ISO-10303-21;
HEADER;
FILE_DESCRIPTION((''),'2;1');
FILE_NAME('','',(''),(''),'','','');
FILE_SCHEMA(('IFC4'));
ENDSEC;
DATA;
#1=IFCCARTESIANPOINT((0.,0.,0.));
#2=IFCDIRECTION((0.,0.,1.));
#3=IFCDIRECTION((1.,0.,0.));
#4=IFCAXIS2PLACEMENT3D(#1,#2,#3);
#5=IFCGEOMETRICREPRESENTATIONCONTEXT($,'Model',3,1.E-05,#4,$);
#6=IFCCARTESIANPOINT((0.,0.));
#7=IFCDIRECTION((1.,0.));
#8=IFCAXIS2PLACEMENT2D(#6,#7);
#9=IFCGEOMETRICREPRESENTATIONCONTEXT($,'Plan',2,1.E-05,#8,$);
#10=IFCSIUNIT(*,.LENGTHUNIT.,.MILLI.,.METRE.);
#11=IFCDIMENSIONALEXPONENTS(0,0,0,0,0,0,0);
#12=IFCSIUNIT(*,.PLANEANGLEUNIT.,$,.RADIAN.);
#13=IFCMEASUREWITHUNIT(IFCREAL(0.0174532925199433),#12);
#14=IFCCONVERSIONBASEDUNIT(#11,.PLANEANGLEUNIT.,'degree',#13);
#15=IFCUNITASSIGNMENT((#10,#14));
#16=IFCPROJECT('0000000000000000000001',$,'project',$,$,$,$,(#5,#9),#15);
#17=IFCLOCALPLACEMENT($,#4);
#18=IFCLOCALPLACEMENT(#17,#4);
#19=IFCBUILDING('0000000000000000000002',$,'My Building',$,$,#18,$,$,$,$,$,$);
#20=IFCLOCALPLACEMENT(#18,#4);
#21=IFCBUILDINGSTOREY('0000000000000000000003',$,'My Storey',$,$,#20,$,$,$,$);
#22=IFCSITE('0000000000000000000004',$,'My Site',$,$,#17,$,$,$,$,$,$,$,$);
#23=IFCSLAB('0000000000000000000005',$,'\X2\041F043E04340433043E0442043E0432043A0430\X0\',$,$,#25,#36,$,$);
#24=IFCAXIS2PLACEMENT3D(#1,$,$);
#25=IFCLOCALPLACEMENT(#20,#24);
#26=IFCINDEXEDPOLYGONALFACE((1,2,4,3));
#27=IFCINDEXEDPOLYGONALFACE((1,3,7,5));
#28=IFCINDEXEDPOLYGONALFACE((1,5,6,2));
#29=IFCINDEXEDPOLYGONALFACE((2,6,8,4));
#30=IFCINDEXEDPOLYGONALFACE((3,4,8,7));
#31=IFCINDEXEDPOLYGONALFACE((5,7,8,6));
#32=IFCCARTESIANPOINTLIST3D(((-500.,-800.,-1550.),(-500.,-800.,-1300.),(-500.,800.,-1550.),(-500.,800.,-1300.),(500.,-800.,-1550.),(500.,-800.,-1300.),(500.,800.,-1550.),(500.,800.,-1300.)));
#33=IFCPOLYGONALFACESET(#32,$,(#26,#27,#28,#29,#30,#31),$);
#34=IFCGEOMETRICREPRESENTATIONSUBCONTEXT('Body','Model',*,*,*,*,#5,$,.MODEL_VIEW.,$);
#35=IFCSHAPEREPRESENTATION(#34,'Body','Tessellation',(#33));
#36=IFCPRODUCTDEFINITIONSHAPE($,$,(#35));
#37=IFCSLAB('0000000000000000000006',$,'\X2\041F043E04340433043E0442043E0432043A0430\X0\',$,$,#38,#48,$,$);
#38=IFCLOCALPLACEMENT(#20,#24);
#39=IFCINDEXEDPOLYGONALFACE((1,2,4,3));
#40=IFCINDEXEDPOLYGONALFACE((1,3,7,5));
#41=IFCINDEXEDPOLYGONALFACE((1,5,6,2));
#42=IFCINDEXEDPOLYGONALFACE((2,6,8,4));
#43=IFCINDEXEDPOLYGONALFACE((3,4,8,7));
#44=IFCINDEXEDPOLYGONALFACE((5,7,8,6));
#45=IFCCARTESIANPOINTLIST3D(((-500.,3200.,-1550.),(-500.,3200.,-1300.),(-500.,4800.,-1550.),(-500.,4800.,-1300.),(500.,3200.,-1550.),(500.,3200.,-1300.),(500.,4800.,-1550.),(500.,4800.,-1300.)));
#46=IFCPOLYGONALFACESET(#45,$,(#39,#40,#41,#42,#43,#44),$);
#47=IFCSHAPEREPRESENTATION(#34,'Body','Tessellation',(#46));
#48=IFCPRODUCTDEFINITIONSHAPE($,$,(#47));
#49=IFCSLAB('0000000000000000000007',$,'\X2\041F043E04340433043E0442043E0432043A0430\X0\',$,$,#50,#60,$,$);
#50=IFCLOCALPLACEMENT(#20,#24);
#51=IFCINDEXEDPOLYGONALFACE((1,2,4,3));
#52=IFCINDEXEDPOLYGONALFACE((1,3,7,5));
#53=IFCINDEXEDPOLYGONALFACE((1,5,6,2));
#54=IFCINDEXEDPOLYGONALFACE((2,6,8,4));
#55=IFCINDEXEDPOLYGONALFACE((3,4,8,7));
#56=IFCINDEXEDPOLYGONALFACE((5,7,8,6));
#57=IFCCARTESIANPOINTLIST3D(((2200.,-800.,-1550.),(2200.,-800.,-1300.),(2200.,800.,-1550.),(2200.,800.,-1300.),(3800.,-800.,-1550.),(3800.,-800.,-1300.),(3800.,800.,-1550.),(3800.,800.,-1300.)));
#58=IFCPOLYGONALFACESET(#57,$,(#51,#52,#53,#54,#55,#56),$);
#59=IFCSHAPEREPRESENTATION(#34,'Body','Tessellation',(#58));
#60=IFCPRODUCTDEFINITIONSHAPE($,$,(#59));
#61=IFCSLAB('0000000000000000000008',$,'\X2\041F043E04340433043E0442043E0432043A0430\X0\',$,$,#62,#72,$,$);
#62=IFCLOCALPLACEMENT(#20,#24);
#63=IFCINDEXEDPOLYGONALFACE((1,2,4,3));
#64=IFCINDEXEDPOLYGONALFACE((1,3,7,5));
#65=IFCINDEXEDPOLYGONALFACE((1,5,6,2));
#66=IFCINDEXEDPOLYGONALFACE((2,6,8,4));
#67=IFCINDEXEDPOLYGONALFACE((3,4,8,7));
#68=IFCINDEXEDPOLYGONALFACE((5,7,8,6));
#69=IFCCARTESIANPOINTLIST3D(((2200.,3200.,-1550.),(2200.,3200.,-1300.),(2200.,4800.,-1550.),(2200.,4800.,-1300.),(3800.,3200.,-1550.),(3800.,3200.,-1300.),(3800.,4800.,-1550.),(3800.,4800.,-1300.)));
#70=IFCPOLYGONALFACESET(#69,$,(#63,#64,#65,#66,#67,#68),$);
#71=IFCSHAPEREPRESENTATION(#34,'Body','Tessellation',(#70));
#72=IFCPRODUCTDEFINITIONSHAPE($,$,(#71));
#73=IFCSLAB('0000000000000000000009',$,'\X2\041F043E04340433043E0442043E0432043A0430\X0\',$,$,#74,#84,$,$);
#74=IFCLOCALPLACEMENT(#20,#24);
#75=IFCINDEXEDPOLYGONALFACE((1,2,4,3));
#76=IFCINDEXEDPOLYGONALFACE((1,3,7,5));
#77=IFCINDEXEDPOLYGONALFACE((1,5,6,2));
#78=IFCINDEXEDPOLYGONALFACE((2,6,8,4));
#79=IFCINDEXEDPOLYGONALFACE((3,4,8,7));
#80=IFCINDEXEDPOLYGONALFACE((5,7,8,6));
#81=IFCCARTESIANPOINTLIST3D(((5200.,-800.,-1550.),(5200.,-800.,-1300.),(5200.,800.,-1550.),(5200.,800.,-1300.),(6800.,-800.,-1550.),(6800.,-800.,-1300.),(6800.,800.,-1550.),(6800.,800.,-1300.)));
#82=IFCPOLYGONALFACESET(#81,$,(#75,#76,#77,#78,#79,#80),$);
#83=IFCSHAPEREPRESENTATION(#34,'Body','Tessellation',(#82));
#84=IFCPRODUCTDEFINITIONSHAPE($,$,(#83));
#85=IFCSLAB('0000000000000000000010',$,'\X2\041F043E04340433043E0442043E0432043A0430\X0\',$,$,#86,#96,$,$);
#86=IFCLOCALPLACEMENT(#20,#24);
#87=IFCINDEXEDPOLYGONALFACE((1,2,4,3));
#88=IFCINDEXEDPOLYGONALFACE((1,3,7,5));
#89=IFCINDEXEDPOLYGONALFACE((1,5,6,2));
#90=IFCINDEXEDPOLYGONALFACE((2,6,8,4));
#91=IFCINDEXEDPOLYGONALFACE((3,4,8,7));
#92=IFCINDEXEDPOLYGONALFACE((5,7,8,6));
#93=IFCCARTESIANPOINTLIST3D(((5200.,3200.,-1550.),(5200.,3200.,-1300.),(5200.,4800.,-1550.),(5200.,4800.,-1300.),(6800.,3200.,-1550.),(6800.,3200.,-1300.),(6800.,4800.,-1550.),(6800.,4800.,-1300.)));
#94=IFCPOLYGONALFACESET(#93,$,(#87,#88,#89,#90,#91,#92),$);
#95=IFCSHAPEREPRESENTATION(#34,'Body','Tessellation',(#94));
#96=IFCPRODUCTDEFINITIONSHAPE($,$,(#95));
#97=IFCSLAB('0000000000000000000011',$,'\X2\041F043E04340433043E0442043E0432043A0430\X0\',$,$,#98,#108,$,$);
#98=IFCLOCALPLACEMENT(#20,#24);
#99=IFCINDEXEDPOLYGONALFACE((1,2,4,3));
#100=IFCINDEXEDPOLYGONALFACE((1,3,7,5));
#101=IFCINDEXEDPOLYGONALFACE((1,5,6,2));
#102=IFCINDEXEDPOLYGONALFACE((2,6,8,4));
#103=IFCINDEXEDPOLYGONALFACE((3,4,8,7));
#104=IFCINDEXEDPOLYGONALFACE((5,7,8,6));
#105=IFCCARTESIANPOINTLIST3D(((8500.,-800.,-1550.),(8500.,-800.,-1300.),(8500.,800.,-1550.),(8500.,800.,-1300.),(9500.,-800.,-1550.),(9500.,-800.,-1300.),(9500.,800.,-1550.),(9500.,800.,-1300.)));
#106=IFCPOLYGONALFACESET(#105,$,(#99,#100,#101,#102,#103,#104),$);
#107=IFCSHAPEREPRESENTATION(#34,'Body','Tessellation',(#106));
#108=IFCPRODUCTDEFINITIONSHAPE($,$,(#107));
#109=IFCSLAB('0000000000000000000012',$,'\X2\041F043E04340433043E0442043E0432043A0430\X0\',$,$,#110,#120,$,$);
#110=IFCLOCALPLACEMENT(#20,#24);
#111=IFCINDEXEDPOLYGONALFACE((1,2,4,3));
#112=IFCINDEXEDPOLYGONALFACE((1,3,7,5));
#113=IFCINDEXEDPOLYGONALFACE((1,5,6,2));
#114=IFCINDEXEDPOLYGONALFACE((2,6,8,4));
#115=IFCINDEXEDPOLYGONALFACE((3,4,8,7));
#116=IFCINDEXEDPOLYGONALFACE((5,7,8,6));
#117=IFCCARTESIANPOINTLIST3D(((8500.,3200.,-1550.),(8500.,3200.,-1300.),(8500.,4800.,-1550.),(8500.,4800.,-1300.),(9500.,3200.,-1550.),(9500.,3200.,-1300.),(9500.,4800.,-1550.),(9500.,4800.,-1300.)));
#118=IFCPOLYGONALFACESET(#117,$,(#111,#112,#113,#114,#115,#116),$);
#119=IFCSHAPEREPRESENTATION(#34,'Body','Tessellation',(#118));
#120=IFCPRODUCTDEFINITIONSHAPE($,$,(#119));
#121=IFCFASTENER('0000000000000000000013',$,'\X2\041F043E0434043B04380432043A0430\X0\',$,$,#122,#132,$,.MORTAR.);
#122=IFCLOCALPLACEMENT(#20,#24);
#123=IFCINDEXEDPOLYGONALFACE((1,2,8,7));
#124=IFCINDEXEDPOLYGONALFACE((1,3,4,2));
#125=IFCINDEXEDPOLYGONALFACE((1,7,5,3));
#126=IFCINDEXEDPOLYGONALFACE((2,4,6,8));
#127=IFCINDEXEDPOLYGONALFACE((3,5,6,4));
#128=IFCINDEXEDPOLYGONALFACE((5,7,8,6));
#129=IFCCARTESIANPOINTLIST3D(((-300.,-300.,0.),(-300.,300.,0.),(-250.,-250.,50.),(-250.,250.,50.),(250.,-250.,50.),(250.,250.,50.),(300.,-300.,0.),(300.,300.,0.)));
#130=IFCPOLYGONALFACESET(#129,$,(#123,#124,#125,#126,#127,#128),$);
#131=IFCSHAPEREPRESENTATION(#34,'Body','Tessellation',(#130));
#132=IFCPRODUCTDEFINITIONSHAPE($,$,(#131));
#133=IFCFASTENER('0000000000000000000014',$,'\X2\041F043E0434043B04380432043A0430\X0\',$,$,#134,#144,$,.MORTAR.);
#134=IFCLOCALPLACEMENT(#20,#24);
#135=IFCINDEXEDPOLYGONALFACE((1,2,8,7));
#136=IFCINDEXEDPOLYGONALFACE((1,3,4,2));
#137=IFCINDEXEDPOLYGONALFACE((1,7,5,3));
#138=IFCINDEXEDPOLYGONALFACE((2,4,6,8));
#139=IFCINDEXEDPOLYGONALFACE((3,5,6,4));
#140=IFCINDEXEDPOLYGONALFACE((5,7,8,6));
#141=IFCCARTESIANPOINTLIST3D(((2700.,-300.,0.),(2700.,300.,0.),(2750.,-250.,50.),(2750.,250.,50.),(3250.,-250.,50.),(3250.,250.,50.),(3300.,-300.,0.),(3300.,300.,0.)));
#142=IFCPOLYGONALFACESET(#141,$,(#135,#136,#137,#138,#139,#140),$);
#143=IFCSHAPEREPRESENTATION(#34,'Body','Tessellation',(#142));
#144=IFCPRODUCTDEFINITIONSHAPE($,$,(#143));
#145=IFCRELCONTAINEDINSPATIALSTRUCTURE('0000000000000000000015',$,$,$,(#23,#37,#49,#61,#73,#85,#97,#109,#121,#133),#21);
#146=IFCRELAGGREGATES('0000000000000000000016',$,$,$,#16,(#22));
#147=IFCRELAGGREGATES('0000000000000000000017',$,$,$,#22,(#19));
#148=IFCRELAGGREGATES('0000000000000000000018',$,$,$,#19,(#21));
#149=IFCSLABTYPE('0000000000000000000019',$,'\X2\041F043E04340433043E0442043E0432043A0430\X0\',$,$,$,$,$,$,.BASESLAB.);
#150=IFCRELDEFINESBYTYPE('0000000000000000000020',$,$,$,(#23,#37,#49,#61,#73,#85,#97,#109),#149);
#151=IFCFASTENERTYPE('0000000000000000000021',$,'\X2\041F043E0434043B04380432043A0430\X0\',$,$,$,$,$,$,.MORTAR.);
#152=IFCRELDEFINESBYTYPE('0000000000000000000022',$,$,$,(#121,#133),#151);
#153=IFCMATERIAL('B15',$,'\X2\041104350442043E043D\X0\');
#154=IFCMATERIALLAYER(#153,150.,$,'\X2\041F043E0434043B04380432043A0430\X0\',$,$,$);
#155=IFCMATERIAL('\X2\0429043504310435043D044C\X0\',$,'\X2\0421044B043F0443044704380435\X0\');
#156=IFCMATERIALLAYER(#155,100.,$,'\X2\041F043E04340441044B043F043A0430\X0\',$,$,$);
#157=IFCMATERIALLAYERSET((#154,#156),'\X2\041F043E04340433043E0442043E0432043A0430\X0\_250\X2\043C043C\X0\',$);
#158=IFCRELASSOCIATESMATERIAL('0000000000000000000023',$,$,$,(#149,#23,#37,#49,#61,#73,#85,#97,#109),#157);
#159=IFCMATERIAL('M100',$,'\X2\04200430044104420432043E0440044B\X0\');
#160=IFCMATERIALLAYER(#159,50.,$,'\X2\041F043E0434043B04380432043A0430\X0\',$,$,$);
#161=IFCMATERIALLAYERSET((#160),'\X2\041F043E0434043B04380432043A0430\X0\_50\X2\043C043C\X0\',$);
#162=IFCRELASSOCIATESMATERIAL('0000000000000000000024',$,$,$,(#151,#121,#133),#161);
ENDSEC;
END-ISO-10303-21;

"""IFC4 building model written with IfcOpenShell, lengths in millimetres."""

from ifc_helpers import new_model, entity, si_unit, converted_unit, frame, origin_with_axes, origin_2d_with_axis, place, context, subcontext, project, spatial, line, indexed_curve, outline, extrude, clip, halfspace, material, layer, layer_set, layer_usage, type_object, element, save


model = new_model("IFC4")

# Units and contexts
model_context = context("Model", 3, precision=1e-05, world=origin_with_axes())
plan_context = context("Plan", 2, precision=1e-05, world=origin_2d_with_axis())
body_context = subcontext(model_context, "Body", "Model", "MODEL_VIEW")
ifc_project = project(units=[si_unit("LENGTHUNIT", "METRE", prefix="MILLI"), converted_unit("PLANEANGLEUNIT", "degree", entity("IfcReal", 0.0174532925199433), si_unit("PLANEANGLEUNIT", "RADIAN"), dimensions=[0, 0, 0, 0, 0, 0, 0])], contexts=[model_context, plan_context])

# Site, building, storey
site_placement = place(None, origin_with_axes())
site = spatial("IfcSite", under=ifc_project, at=site_placement, Name="My Site")
building_placement = place(site_placement, origin_with_axes())
building = spatial("IfcBuilding", under=site, at=building_placement, Name="My Building")
storey_placement = place(building_placement, origin_with_axes())
storey = spatial("IfcBuildingStorey", under=building, at=storey_placement, Name="My Storey")

# Slabs
ifc_material_1 = material(Name="B15", Category="Бетон")
ifc_layer_1 = layer(ifc_material_1, 150.0, Name="Подливка")
ifc_material_2 = material(Name="Щебень", Category="Сыпучие")
ifc_layer_2 = layer(ifc_material_2, 100.0, Name="Подсыпка")
ifc_layer_set_1 = layer_set([ifc_layer_1, ifc_layer_2], Name="Подготовка_250мм")
ifc_layer_usage_1 = layer_usage(ifc_layer_set_1, "AXIS3", "NEGATIVE", 0.0)
slab_type = type_object("IfcSlabType", Name="Подготовка", PredefinedType="BASESLAB", material=ifc_layer_set_1)
for number, where, z_axis, x_axis, name in (
    (1, (0.0, 0.0, -1550.0), (0.0, 0.0, 1.0), (1.0, 0.0, 0.0), "Подготовка"),
    (2, (0.0, 4000.0, -1550.0), (0.0, 0.0, 1.0), (1.0, 0.0, 0.0), "Подготовка"),
):
    element("IfcSlab", number, at=place(storey_placement, frame(where, z_axis=z_axis, x_axis=x_axis)), inside=storey, type_object=slab_type, material=ifc_layer_usage_1, Name=name, context=body_context, shape_type="SweptSolid", body=[
        extrude(outline(indexed_curve([(-500.0, -800.0), (500.0, -800.0), (500.0, 800.0), (-500.0, 800.0)], segments=[line(3, 2), line(2, 1), line(1, 4), line(4, 3)], self_intersect=False)), None, (0.0, 0.0, 1.0), 250.0),
    ])
slab_1_placement = place(storey_placement, frame((3000.0, 0.0, -1550.0), z_axis=(0.0, 0.0, 1.0), x_axis=(1.0, 0.0, 0.0)))
element("IfcSlab", 3, at=slab_1_placement, inside=storey, type_object=slab_type, material=ifc_layer_usage_1, Name="Подготовка", context=body_context, shape_type="SweptSolid", body=[
    extrude(outline(indexed_curve([(800.0, 800.0), (800.0, -800.0), (-800.0, -800.0), (-800.0, 800.0)], segments=[line(3, 2), line(2, 1), line(1, 4), line(4, 3)], self_intersect=False)), None, (0.0, 0.0, 1.0), 250.0),
])
slab_2_placement = place(storey_placement, frame((3000.0, 4000.0, -1550.0), z_axis=(0.0, 0.0, 1.0), x_axis=(1.0, 0.0, 0.0)))
element("IfcSlab", 4, at=slab_2_placement, inside=storey, type_object=slab_type, material=ifc_layer_usage_1, Name="Подготовка", context=body_context, shape_type="SweptSolid", body=[
    extrude(outline(indexed_curve([(-800.0, -800.0), (800.0, -800.0), (800.0, 800.0), (-800.0, 800.0)], segments=[line(3, 2), line(2, 1), line(1, 4), line(4, 3)], self_intersect=False)), None, (0.0, 0.0, 1.0), 250.0),
])
for number, where, z_axis, x_axis, name in (
    (5, (6000.0, 0.0, -1550.0), (0.0, 0.0, 1.0), (1.0, 0.0, 0.0), "Подготовка"),
    (6, (6000.0, 4000.0, -1550.0), (0.0, 0.0, 1.0), (1.0, 0.0, 0.0), "Подготовка"),
):
    element("IfcSlab", number, at=place(storey_placement, frame(where, z_axis=z_axis, x_axis=x_axis)), inside=storey, type_object=slab_type, material=ifc_layer_usage_1, Name=name, context=body_context, shape_type="SweptSolid", body=[
        extrude(outline(indexed_curve([(800.0, 800.0), (800.0, -800.0), (-800.0, -800.0), (-800.0, 800.0)], segments=[line(3, 2), line(2, 1), line(1, 4), line(4, 3)], self_intersect=False)), None, (0.0, 0.0, 1.0), 250.0),
    ])
slab_3_placement = place(storey_placement, frame((9000.0, 0.0, -1550.0), z_axis=(0.0, 0.0, 1.0), x_axis=(1.0, 0.0, 0.0)))
element("IfcSlab", 7, at=slab_3_placement, inside=storey, type_object=slab_type, material=ifc_layer_usage_1, Name="Подготовка", context=body_context, shape_type="SweptSolid", body=[
    extrude(outline(indexed_curve([(500.0, 800.0), (500.0, -800.0), (-500.0, -800.0), (-500.0, 800.0)], segments=[line(3, 2), line(2, 1), line(1, 4), line(4, 3)], self_intersect=False)), None, (0.0, 0.0, 1.0), 250.0),
])
slab_4_placement = place(storey_placement, frame((9000.0, 4000.0, -1550.0), z_axis=(0.0, 0.0, 1.0), x_axis=(1.0, 0.0, 0.0)))
element("IfcSlab", 8, at=slab_4_placement, inside=storey, type_object=slab_type, material=ifc_layer_usage_1, Name="Подготовка", context=body_context, shape_type="SweptSolid", body=[
    extrude(outline(indexed_curve([(-500.0, -800.0), (500.0, -800.0), (500.0, 800.0), (-500.0, 800.0)], segments=[line(3, 2), line(2, 1), line(1, 4), line(4, 3)], self_intersect=False)), None, (0.0, 0.0, 1.0), 250.0),
])

# Fasteners
ifc_material_3 = material(Name="M100", Category="Растворы")
ifc_layer_3 = layer(ifc_material_3, 50.0, Name="Подливка")
ifc_layer_set_2 = layer_set([ifc_layer_3], Name="Подливка_50мм")
ifc_layer_usage_2 = layer_usage(ifc_layer_set_2, "AXIS3", "POSITIVE", 0.0)
fastener_type = type_object("IfcFastenerType", Name="Подливка", PredefinedType="MORTAR", material=ifc_layer_set_2)
placement = place(storey_placement, origin_with_axes())
element("IfcFastener", 9, at=placement, inside=storey, type_object=fastener_type, material=ifc_layer_usage_2, Name="Подливка", PredefinedType="MORTAR", context=body_context, shape_type="Clipping", body=[
    clip(clip(clip(clip(extrude(outline(indexed_curve([(-300.0, -300.0), (300.0, -300.0), (300.0, 300.0), (-300.0, 300.0)], segments=[line(3, 2), line(2, 1), line(1, 4), line(4, 3)], self_intersect=False)), None, (0.0, 0.0, 1.0), 50.0), halfspace(frame((-53.6, 200.0, 353.6), z_axis=(0.707107, 0.0, 0.707107), x_axis=(0.707107, 0.0, -0.707107)), False)), halfspace(frame((-200.0, -53.6, 353.6), z_axis=(0.0, 0.707107, 0.707107), x_axis=(0.0, 0.707107, -0.707107)), False)), halfspace(frame((200.0, 53.6, 353.6), z_axis=(0.0, -0.707107, 0.707107), x_axis=(0.0, -0.707107, -0.707107)), False)), halfspace(frame((53.6, 200.0, 353.6), z_axis=(-0.707107, 0.0, 0.707107), x_axis=(-0.707107, 0.0, -0.707107)), False)),
])
fastener_1_placement = place(storey_placement, frame((3000.0, 0.0, 0.0), z_axis=(0.0, 0.0, 1.0), x_axis=(1.0, 0.0, 0.0)))
element("IfcFastener", 10, at=fastener_1_placement, inside=storey, type_object=fastener_type, material=ifc_layer_usage_2, Name="Подливка", PredefinedType="MORTAR", context=body_context, shape_type="Clipping", body=[
    clip(clip(clip(clip(extrude(outline(indexed_curve([(-300.0, -300.0), (300.0, -300.0), (300.0, 300.0), (-300.0, 300.0)], segments=[line(3, 2), line(2, 1), line(1, 4), line(4, 3)], self_intersect=False)), None, (0.0, 0.0, 1.0), 50.0), halfspace(frame((-53.6, 200.0, 353.6), z_axis=(0.707107, 0.0, 0.707107), x_axis=(0.707107, 0.0, -0.707107)), False)), halfspace(frame((-200.0, -53.6, 353.6), z_axis=(0.0, 0.707107, 0.707107), x_axis=(0.0, 0.707107, -0.707107)), False)), halfspace(frame((200.0, 53.6, 353.6), z_axis=(0.0, -0.707107, 0.707107), x_axis=(0.0, -0.707107, -0.707107)), False)), halfspace(frame((53.6, 200.0, 353.6), z_axis=(-0.707107, 0.0, 0.707107), x_axis=(-0.707107, 0.0, -0.707107)), False)),
])

save(model, "model.ifc")
